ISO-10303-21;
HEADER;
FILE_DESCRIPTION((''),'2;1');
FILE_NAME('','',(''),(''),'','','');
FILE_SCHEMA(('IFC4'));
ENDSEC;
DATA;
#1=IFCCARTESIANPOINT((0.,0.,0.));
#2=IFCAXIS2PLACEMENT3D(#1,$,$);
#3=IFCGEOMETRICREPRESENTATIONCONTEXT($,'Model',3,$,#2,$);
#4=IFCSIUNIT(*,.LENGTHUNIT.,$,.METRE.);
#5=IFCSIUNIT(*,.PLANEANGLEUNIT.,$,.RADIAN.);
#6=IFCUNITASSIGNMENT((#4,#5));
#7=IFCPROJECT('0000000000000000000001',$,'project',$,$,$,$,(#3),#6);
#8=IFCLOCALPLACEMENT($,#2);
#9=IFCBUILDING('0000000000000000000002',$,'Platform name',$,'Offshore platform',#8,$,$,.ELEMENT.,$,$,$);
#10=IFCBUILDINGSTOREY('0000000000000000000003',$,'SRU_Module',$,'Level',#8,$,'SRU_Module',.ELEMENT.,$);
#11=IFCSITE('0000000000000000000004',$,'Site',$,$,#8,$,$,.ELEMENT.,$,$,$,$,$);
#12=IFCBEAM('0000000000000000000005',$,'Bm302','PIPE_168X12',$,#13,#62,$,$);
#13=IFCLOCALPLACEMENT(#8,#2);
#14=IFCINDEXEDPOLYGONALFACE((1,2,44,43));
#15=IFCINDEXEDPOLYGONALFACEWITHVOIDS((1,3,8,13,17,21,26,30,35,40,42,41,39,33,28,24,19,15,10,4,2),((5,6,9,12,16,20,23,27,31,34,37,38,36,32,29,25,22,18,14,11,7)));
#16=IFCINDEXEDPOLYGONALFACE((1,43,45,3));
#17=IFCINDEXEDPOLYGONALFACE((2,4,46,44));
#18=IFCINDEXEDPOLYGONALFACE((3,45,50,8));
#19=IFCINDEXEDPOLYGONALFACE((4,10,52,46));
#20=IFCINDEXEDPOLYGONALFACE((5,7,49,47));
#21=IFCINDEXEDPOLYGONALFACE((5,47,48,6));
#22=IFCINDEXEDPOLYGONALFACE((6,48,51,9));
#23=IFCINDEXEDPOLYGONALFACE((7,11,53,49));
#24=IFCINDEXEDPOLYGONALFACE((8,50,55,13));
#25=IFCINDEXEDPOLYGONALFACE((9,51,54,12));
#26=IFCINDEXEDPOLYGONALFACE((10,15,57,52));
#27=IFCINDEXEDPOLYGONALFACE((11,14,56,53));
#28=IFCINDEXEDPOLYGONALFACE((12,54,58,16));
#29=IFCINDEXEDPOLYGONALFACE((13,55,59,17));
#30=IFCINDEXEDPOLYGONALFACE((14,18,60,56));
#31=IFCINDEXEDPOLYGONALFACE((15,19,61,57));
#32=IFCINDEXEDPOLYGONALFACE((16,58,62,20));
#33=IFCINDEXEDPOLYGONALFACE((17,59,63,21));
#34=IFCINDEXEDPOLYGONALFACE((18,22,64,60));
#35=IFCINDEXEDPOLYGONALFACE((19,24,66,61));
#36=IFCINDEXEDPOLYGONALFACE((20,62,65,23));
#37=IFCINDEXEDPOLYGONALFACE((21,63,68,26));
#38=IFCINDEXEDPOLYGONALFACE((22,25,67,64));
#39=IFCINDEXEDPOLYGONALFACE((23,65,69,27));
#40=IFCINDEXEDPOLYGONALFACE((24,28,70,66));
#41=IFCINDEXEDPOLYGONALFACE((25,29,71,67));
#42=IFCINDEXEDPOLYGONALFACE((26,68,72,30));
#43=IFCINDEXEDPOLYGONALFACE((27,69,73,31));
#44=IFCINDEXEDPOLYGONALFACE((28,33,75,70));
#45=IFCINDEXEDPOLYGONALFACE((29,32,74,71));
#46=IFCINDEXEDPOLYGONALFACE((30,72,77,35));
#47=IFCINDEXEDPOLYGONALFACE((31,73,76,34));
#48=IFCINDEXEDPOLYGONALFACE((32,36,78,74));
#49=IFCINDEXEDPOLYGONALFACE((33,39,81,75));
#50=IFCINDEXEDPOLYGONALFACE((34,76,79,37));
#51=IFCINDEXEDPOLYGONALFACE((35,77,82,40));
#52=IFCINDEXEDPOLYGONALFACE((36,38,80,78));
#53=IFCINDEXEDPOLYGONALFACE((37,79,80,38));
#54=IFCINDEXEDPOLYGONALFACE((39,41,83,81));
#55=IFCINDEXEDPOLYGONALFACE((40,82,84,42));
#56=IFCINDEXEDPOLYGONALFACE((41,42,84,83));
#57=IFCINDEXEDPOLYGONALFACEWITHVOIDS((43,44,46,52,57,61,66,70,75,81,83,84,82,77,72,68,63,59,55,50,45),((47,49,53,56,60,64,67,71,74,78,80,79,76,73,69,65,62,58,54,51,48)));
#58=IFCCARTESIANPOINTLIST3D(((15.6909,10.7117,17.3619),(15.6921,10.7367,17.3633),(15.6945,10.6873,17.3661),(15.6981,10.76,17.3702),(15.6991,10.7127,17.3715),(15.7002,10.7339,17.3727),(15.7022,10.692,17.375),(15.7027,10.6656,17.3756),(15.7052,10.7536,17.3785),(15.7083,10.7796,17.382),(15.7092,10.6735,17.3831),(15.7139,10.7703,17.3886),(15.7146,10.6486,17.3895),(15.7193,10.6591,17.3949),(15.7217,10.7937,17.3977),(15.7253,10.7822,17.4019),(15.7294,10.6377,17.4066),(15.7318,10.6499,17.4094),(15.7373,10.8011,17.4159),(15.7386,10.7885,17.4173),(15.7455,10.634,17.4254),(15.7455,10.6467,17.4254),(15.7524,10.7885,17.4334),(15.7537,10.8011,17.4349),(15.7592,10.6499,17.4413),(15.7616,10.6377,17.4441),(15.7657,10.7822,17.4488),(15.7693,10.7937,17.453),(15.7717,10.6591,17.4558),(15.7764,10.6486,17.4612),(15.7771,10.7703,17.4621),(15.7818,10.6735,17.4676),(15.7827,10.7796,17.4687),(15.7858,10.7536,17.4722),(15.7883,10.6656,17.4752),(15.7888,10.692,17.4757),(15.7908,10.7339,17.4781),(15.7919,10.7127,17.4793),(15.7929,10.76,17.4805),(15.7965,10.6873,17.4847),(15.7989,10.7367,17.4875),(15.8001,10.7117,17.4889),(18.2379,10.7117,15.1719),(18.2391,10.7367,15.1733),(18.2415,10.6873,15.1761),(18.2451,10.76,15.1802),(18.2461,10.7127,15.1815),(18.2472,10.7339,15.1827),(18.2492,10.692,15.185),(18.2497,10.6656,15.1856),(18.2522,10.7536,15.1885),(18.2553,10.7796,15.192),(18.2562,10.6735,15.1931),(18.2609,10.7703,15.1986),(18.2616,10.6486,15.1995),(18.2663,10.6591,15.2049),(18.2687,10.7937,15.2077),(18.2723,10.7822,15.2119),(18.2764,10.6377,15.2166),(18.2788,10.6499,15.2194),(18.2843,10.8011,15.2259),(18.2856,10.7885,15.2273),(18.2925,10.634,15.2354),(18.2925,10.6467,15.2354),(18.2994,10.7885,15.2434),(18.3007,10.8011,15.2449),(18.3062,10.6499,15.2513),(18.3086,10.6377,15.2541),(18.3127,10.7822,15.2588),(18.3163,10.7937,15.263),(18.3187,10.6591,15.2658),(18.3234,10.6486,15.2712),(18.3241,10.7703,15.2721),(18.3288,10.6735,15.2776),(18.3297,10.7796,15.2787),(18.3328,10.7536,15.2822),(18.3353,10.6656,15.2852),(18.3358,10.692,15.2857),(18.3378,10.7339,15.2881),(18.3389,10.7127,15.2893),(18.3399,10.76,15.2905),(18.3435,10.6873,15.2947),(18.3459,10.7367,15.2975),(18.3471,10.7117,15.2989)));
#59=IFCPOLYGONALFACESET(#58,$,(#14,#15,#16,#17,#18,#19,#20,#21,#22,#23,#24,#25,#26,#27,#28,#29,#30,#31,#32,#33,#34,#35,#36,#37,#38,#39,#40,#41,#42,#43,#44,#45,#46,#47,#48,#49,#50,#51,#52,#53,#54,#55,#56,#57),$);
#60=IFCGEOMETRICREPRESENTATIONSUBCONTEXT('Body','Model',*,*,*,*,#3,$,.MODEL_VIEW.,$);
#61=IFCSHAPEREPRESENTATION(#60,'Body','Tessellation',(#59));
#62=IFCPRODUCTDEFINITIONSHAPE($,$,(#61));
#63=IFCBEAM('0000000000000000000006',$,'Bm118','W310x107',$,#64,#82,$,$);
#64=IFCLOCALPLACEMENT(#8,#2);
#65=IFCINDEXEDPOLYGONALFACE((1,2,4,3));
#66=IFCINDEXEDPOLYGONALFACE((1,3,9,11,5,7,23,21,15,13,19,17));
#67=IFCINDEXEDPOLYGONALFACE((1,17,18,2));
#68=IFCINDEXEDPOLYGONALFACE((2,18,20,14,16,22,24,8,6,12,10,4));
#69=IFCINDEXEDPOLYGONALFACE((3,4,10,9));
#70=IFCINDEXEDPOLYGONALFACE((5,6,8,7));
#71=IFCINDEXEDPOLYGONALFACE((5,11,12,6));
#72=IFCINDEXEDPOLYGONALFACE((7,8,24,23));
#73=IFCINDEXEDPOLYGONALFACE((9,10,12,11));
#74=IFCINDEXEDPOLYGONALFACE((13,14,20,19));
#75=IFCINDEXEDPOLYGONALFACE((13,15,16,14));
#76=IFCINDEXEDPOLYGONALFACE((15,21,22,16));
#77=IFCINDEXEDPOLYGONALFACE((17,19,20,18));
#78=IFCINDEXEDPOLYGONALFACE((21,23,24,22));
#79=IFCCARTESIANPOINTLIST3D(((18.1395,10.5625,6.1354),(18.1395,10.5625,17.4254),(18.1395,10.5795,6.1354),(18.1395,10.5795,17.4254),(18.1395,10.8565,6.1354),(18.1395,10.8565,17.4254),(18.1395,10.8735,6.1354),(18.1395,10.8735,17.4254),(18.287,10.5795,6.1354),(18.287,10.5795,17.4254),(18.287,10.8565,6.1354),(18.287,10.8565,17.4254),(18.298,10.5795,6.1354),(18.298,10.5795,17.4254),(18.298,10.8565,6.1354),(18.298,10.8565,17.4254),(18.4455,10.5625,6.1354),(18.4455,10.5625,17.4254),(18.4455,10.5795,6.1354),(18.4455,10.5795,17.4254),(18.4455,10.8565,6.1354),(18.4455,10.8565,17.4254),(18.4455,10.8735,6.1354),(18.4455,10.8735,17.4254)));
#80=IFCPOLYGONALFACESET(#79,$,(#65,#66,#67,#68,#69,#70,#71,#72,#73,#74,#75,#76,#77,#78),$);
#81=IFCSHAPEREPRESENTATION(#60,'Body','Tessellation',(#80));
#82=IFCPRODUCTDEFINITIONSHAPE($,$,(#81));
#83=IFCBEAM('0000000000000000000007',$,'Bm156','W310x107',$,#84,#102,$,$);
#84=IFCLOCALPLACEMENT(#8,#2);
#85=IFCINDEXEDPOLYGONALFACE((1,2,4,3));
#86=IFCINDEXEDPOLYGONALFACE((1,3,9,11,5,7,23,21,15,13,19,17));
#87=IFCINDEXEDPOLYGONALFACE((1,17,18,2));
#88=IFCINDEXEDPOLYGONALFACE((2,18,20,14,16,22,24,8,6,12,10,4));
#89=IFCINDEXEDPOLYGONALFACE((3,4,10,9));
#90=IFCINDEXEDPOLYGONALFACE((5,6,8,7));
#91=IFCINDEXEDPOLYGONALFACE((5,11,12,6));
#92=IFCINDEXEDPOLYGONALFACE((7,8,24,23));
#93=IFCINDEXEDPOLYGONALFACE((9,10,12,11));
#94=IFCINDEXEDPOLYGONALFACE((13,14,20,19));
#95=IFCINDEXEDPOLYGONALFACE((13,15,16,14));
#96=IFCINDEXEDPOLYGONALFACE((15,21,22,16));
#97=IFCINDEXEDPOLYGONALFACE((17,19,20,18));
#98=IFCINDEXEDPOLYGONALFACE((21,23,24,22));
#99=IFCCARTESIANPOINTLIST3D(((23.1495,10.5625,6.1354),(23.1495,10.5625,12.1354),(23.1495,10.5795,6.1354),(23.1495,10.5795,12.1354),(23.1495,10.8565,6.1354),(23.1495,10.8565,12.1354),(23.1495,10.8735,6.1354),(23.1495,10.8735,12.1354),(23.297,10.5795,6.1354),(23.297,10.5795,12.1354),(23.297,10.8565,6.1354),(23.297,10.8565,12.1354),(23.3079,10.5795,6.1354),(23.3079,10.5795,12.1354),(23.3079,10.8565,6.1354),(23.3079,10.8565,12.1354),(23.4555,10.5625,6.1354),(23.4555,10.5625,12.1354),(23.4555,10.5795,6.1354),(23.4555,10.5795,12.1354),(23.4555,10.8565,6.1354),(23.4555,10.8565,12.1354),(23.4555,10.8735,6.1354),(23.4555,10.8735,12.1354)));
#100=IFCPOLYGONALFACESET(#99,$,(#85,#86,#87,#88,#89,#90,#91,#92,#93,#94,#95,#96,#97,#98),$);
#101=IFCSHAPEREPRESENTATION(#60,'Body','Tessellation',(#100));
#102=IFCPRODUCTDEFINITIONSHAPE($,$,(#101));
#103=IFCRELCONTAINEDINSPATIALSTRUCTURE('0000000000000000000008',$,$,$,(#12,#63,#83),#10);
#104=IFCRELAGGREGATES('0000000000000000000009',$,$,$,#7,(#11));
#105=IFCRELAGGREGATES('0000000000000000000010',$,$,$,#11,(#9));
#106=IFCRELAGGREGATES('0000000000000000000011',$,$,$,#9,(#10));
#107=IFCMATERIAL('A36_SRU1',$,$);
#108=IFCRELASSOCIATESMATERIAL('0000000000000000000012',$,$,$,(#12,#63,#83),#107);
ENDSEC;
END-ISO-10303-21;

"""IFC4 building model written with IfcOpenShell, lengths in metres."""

from ifc_helpers import new_model, si_unit, frame, origin, origin_with_axes, origin_2d, place, context, subcontext, project, spatial, hollow_circle, i_section, extrude, source, transform, mapped, material, element, save


model = new_model("IFC4")

# Units and contexts
model_context = context("Model", 3, world=origin())
body_context = subcontext(model_context, "Body", "Model", "MODEL_VIEW")
ifc_project = project(units=[si_unit("LENGTHUNIT", "METRE"), si_unit("PLANEANGLEUNIT", "RADIAN")], contexts=[model_context])

# Site, building, storey
placement_1 = place(None, origin())
site = spatial("IfcSite", under=ifc_project, at=placement_1, Name="Site", CompositionType="ELEMENT")
building = spatial("IfcBuilding", under=site, at=placement_1, Name="Platform name", ObjectType="Offshore platform", CompositionType="ELEMENT")
storey = spatial("IfcBuildingStorey", under=building, at=placement_1, Name="SRU_Module", ObjectType="Level", LongName="SRU_Module", CompositionType="ELEMENT")

# Beams
ifc_material = material(Name="A36_SRU1")
shared_shape_1 = source(origin(), body_context, "Body", "SweptSolid", [
    extrude(hollow_circle(Radius=0.084, WallThickness=0.0127, at=origin_2d()), frame((0.0, 0.0, 0.0), z_axis=(-0.758247, 0.0, 0.651967), x_axis=(0.0, -1.0, 0.0)), (0.0, 0.0, 1.0), 3.3591),
])
placement_2 = place(None, origin())
placement_3 = place(placement_2, origin())
placement_4 = place(placement_3, origin())
beam_1_placement = place(placement_4, frame((18.2925, 10.718, 15.2354)))
element("IfcBeam", 1, at=beam_1_placement, inside=storey, material=ifc_material, Name="Bm302", Description="PIPE_168X12", context=body_context, shape_type="MappedRepresentation", body=[
    mapped(shared_shape_1, transform((0.0, 0.0, 0.0), scale=1.0)),
])
shared_shape_2 = source(origin(), body_context, "Body", "SweptSolid", [
    extrude(i_section(OverallWidth=0.306, OverallDepth=0.311, WebThickness=0.0109, FlangeThickness=0.017, FilletRadius=0.0, at=origin_2d()), origin_with_axes(), (0.0, 0.0, 1.0), 11.29),
])
placement_5 = place(None, origin())
placement_6 = place(placement_5, origin())
placement_7 = place(placement_6, origin())
beam_2_placement = place(placement_7, frame((18.2925, 10.718, 6.1354)))
element("IfcBeam", 2, at=beam_2_placement, inside=storey, material=ifc_material, Name="Bm118", Description="W310x107", context=body_context, shape_type="MappedRepresentation", body=[
    mapped(shared_shape_2, transform((0.0, 0.0, 0.0), scale=1.0)),
])
shared_shape_3 = source(origin(), body_context, "Body", "SweptSolid", [
    extrude(i_section(OverallWidth=0.306, OverallDepth=0.311, WebThickness=0.0109, FlangeThickness=0.017, FilletRadius=0.0, at=origin_2d()), origin_with_axes(), (0.0, 0.0, 1.0), 6.0),
])
placement_8 = place(None, origin())
placement_9 = place(placement_8, origin())
placement_10 = place(placement_9, origin())
beam_3_placement = place(placement_10, frame((23.3025, 10.718, 6.1354)))
element("IfcBeam", 3, at=beam_3_placement, inside=storey, material=ifc_material, Name="Bm156", Description="W310x107", context=body_context, shape_type="MappedRepresentation", body=[
    mapped(shared_shape_3, transform((0.0, 0.0, 0.0), scale=1.0)),
])

save(model, "model.ifc")
